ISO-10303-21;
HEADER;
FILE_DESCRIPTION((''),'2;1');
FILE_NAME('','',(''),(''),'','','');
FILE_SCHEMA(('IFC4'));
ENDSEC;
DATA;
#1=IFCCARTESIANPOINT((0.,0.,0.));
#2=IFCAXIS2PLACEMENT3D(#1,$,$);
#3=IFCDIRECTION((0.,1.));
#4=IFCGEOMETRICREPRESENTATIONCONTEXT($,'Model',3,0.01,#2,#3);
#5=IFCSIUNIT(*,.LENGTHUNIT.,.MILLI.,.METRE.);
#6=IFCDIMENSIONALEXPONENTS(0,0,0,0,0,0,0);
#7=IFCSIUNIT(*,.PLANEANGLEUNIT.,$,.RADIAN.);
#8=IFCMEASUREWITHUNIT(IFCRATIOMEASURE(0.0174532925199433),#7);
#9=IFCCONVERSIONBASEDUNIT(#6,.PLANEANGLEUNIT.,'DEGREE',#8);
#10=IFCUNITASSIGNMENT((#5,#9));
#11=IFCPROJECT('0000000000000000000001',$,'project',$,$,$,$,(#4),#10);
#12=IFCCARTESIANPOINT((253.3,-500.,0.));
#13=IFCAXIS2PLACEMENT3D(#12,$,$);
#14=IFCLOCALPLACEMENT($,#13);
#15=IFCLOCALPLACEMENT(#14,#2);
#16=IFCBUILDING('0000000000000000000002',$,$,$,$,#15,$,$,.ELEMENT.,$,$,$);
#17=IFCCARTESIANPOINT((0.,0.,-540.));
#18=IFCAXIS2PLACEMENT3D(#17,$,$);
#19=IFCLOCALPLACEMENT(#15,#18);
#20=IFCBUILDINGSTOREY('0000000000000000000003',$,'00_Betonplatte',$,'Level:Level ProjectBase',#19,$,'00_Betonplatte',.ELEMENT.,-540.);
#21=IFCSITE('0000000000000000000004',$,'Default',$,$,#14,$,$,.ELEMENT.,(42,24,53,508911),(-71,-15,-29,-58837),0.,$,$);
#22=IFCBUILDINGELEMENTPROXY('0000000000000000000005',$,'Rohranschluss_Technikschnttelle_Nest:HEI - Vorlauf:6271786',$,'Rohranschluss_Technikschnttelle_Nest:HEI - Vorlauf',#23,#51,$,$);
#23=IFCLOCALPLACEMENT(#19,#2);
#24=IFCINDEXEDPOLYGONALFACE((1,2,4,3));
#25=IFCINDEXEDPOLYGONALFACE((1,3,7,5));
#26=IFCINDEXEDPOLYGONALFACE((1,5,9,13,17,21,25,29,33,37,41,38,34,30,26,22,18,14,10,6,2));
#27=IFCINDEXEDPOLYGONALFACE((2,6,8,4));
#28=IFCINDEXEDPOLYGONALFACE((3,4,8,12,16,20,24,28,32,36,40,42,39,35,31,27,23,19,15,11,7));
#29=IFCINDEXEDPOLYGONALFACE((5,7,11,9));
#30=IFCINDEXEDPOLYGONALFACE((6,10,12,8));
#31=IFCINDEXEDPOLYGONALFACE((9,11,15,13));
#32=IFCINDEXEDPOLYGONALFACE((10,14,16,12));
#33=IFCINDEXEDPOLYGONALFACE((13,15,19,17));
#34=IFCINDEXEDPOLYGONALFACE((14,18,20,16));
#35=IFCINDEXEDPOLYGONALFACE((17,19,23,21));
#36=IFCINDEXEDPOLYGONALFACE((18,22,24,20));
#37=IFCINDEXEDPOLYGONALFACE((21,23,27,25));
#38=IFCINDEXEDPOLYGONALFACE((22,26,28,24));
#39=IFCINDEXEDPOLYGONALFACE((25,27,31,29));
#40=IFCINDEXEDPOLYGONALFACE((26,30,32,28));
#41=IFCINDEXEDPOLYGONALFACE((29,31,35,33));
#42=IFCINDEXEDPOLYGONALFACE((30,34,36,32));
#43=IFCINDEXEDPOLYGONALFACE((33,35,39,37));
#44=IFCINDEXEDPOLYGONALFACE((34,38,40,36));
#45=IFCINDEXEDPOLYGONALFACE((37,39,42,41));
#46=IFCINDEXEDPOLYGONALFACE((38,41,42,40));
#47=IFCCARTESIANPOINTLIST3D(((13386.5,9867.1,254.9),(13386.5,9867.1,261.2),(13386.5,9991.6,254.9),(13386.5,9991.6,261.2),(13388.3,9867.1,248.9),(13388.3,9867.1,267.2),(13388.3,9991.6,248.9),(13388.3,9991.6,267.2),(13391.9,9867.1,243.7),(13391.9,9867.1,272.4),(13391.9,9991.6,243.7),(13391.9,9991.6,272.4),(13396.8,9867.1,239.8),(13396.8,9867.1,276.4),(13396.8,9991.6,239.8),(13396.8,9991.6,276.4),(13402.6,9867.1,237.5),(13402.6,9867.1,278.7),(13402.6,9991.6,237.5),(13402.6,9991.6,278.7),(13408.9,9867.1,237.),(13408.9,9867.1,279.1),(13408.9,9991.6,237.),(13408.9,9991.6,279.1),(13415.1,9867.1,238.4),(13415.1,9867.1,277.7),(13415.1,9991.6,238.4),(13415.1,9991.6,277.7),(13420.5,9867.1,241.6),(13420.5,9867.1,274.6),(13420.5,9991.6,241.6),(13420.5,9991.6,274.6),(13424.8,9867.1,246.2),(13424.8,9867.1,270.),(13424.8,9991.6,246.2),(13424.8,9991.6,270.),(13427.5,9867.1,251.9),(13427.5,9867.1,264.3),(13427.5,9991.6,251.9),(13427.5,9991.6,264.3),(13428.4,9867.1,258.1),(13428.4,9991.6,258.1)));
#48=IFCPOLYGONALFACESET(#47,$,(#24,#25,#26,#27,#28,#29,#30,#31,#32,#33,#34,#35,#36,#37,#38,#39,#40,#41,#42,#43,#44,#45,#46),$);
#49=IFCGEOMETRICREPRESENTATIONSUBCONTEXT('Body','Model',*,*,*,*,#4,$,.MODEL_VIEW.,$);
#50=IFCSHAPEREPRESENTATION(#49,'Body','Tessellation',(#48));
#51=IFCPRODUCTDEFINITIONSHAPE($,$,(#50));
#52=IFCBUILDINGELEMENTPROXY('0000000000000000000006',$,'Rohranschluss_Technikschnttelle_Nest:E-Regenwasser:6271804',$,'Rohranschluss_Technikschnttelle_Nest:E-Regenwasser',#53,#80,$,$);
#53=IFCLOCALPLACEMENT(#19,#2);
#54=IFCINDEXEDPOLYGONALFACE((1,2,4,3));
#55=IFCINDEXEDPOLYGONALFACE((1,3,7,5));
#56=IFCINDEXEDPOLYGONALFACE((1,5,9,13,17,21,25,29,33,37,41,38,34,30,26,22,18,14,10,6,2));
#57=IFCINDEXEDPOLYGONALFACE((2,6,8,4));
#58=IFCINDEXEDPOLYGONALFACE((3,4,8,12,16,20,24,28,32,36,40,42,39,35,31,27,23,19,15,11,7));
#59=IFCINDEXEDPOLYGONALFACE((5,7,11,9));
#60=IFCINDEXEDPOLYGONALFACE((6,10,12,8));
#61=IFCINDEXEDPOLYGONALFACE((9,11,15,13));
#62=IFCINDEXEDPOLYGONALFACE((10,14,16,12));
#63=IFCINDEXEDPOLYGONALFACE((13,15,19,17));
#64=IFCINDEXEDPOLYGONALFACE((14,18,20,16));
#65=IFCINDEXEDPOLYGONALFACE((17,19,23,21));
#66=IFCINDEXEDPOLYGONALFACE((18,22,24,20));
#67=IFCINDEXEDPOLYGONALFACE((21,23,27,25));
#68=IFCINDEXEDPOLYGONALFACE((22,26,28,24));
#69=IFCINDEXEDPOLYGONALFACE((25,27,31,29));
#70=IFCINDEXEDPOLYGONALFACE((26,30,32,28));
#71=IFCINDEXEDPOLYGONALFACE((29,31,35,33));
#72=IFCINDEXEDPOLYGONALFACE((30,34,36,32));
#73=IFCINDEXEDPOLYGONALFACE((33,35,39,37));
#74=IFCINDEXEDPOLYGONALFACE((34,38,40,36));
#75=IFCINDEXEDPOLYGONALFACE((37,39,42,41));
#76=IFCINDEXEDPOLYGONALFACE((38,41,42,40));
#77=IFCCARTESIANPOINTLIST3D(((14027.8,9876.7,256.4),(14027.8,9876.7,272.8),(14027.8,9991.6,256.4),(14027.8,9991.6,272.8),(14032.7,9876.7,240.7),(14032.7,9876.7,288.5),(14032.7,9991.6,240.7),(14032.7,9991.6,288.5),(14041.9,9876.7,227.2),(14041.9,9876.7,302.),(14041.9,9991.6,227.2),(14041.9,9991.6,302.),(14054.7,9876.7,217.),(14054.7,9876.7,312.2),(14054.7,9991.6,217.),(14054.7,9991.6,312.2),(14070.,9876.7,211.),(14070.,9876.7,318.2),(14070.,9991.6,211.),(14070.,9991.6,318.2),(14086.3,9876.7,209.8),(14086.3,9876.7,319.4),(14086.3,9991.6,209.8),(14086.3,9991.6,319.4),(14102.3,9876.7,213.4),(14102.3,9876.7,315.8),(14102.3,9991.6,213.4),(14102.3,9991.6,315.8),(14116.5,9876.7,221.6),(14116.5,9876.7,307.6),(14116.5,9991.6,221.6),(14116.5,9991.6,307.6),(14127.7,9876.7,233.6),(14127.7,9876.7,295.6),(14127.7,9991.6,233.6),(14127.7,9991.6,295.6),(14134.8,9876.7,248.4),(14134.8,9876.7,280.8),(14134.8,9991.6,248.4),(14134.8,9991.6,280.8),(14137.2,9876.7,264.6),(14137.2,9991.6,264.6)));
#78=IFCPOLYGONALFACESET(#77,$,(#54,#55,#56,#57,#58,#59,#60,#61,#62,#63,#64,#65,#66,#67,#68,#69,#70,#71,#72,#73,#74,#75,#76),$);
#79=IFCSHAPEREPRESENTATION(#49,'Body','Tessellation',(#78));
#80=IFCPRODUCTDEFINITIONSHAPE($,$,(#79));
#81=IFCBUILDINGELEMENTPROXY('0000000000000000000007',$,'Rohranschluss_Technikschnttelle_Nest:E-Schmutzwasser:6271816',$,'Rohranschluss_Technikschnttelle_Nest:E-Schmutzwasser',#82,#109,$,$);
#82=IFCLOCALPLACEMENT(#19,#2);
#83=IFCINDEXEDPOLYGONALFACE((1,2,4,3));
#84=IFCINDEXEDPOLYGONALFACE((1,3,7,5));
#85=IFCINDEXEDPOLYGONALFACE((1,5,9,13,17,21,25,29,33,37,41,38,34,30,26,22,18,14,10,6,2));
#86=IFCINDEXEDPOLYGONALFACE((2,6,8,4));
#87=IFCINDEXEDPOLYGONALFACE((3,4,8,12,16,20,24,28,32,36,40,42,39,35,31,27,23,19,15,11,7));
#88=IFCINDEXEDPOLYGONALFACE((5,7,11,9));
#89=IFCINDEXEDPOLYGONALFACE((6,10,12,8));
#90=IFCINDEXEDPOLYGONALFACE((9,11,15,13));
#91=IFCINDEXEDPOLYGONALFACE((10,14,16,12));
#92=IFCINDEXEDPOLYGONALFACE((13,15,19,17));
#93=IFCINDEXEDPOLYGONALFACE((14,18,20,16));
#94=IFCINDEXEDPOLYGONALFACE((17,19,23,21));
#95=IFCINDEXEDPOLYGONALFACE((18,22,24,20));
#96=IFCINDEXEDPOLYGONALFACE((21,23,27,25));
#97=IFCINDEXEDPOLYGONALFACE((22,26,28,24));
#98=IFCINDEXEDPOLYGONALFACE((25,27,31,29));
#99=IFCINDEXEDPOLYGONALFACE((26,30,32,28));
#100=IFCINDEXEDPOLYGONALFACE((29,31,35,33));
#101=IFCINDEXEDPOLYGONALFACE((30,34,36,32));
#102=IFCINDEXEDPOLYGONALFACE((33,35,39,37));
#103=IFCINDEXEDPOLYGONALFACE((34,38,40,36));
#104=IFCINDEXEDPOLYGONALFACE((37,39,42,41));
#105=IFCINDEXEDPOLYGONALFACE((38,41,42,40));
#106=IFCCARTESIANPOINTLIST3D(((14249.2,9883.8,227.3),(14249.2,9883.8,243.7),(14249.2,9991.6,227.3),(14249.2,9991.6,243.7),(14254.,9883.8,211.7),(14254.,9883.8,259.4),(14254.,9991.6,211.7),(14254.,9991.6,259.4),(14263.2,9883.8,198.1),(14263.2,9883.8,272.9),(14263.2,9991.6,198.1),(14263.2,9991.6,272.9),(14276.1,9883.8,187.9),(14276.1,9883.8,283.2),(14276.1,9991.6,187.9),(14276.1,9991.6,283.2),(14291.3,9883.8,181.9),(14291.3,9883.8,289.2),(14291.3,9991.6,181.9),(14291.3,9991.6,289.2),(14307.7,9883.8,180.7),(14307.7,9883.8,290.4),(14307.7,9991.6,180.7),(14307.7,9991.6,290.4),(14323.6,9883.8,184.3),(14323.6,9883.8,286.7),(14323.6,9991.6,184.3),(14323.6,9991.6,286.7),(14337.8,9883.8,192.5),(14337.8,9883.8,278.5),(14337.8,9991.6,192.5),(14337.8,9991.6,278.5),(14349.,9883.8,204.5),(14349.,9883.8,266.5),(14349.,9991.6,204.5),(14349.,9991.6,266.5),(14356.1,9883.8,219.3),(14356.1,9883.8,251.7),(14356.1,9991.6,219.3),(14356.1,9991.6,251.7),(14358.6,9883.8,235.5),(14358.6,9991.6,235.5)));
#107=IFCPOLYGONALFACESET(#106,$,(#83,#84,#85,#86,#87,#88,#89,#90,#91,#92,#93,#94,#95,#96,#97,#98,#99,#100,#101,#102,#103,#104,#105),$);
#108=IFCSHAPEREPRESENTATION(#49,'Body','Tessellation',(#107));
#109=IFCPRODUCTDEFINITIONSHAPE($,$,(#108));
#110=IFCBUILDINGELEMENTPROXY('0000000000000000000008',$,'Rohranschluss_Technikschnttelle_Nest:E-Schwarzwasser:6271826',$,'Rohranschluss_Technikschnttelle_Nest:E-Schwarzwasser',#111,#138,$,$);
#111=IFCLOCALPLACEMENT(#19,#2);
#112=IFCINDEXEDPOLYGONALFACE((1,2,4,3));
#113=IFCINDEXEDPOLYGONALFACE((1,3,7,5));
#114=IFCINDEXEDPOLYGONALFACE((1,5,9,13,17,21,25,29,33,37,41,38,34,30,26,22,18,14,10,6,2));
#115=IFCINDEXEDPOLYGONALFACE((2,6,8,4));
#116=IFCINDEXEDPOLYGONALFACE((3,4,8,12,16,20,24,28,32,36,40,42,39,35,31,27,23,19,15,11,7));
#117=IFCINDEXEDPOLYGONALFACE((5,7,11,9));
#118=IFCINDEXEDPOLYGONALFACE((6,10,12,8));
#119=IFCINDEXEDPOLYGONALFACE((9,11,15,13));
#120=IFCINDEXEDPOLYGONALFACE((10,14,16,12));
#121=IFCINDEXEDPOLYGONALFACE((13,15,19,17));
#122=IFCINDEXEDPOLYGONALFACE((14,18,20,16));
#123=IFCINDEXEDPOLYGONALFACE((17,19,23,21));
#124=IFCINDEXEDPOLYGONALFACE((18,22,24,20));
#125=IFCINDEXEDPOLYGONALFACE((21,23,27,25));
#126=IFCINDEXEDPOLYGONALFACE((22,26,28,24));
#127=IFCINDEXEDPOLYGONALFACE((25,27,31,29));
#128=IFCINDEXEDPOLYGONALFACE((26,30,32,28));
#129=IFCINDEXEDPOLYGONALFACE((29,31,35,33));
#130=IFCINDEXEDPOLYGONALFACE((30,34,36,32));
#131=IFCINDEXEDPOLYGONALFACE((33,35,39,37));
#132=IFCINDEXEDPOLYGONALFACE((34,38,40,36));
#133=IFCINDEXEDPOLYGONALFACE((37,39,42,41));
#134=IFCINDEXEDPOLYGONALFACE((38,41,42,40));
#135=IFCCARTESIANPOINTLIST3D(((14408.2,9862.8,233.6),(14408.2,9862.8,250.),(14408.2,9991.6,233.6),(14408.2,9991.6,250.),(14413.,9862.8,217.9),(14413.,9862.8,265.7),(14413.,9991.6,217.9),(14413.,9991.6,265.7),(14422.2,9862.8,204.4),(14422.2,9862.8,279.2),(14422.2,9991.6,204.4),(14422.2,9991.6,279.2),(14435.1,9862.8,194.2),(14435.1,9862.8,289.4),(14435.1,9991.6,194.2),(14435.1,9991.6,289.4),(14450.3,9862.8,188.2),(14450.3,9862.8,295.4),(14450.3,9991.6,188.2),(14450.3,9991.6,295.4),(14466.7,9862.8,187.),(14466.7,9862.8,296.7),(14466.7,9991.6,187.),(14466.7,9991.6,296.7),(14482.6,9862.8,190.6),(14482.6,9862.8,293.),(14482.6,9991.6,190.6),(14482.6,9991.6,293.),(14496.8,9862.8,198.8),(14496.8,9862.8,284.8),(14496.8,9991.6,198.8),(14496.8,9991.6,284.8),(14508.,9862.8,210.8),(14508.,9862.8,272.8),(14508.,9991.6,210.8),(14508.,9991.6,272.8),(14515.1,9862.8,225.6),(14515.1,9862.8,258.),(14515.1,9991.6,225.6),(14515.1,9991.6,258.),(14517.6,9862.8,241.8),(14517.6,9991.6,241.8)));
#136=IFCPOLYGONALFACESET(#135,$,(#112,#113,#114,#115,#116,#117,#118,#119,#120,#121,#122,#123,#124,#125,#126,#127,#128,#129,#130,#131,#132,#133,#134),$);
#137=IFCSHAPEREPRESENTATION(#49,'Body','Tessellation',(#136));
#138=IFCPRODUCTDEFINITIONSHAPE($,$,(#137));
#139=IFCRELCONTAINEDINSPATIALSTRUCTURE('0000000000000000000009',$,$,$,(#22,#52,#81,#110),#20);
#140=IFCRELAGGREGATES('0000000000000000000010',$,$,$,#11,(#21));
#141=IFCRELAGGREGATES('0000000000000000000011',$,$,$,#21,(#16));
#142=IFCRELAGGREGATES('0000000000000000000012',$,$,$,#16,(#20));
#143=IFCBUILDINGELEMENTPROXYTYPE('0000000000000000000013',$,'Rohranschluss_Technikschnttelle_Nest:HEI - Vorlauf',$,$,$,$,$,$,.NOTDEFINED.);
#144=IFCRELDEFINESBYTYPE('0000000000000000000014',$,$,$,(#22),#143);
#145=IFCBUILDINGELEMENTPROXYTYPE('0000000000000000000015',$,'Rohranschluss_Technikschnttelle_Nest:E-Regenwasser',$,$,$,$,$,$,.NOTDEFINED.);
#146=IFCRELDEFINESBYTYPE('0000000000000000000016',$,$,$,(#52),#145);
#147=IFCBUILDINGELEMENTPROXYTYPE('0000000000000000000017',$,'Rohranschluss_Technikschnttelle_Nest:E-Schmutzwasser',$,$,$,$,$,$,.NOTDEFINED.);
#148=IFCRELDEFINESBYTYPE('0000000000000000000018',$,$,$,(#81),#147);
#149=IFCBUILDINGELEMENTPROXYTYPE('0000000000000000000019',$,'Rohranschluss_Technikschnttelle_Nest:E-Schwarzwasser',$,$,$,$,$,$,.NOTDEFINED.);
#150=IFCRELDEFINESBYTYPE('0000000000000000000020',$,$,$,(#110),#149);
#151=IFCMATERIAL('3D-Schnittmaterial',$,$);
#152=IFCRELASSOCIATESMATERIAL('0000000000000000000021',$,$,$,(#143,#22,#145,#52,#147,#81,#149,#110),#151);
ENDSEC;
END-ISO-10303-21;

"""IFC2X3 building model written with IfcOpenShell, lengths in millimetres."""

from ifc_helpers import new_model, entity, si_unit, converted_unit, direction, frame, frame_2d, origin, place, context, subcontext, project, spatial, circle, extrude, source, transform, mapped, material, type_object, type_shapes, element, save


model = new_model("IFC2X3")

# Units and contexts
model_context = context("Model", 3, precision=0.01, world=origin(), true_north=direction((0.0, 1.0)))
body_context = subcontext(model_context, "Body", "Model", "MODEL_VIEW")
ifc_project = project(units=[si_unit("LENGTHUNIT", "METRE", prefix="MILLI"), converted_unit("PLANEANGLEUNIT", "DEGREE", entity("IfcRatioMeasure", 0.0174532925199433), si_unit("PLANEANGLEUNIT", "RADIAN"), dimensions=[0, 0, 0, 0, 0, 0, 0])], contexts=[model_context])

# Site, building, storey
site_placement = place(None, frame((253.3, -500.0, 0.0)))
site = spatial("IfcSite", under=ifc_project, at=site_placement, Name="Default", CompositionType="ELEMENT", RefLatitude=(42, 24, 53, 508911), RefLongitude=(-71, -15, -29, -58837), RefElevation=0.0)
building_placement = place(site_placement, origin())
building = spatial("IfcBuilding", under=site, at=building_placement, CompositionType="ELEMENT")
storey_placement = place(building_placement, frame((0.0, 0.0, -540.0)))
storey = spatial("IfcBuildingStorey", under=building, at=storey_placement, Name="00_Betonplatte", ObjectType="Level:Level ProjectBase", LongName="00_Betonplatte", CompositionType="ELEMENT", Elevation=-540.0)

# Building element proxies
ifc_material_1 = material(Name="3D-Schnittmaterial")
building_element_proxy_type_1 = type_object("IfcBuildingElementProxyType", Name="Rohranschluss_Technikschnttelle_Nest:HEI - Vorlauf", PredefinedType="NOTDEFINED", material=ifc_material_1)
shared_shape_1 = source(origin(), body_context, "Body", "SweptSolid", [
    extrude(circle(Radius=21.1, at=frame_2d((0.0, 0.0), x_axis=(1.0, 0.0))), frame((0.0, -124.5, 0.0), z_axis=(0.0, 1.0, 0.0), x_axis=(1.0, 0.0, 0.0)), (0.0, 0.0, 1.0), 124.5),
])
type_shapes(building_element_proxy_type_1, [shared_shape_1])
proxy_1_placement = place(storey_placement, frame((13407.3, 9991.6, 258.1)))
element("IfcBuildingElementProxy", 1, at=proxy_1_placement, inside=storey, type_object=building_element_proxy_type_1, material=ifc_material_1, Name="Rohranschluss_Technikschnttelle_Nest:HEI - Vorlauf:6271786", ObjectType="Rohranschluss_Technikschnttelle_Nest:HEI - Vorlauf", context=body_context, shape_type="MappedRepresentation", body=[
    mapped(shared_shape_1, transform((0.0, 0.0, 0.0), scale=1.0)),
])
building_element_proxy_type_2 = type_object("IfcBuildingElementProxyType", Name="Rohranschluss_Technikschnttelle_Nest:E-Regenwasser", PredefinedType="NOTDEFINED", material=ifc_material_1)
shared_shape_2 = source(origin(), body_context, "Body", "SweptSolid", [
    extrude(circle(Radius=55.0, at=frame_2d((0.0, 0.0), x_axis=(1.0, 0.0))), frame((0.0, -115.0, 0.0), z_axis=(0.0, 1.0, 0.0), x_axis=(1.0, 0.0, 0.0)), (0.0, 0.0, 1.0), 115.0),
])
type_shapes(building_element_proxy_type_2, [shared_shape_2])
proxy_2_placement = place(storey_placement, frame((14082.2, 9991.6, 264.6)))
element("IfcBuildingElementProxy", 2, at=proxy_2_placement, inside=storey, type_object=building_element_proxy_type_2, material=ifc_material_1, Name="Rohranschluss_Technikschnttelle_Nest:E-Regenwasser:6271804", ObjectType="Rohranschluss_Technikschnttelle_Nest:E-Regenwasser", context=body_context, shape_type="MappedRepresentation", body=[
    mapped(shared_shape_2, transform((0.0, 0.0, 0.0), scale=1.0)),
])
building_element_proxy_type_3 = type_object("IfcBuildingElementProxyType", Name="Rohranschluss_Technikschnttelle_Nest:E-Schmutzwasser", PredefinedType="NOTDEFINED", material=ifc_material_1)
shared_shape_3 = source(origin(), body_context, "Body", "SweptSolid", [
    extrude(circle(Radius=55.0, at=frame_2d((0.0, 0.0), x_axis=(1.0, 0.0))), frame((0.0, -107.9, 0.0), z_axis=(0.0, 1.0, 0.0), x_axis=(1.0, 0.0, 0.0)), (0.0, 0.0, 1.0), 107.9),
])
type_shapes(building_element_proxy_type_3, [shared_shape_3])
proxy_3_placement = place(storey_placement, frame((14303.6, 9991.6, 235.5)))
element("IfcBuildingElementProxy", 3, at=proxy_3_placement, inside=storey, type_object=building_element_proxy_type_3, material=ifc_material_1, Name="Rohranschluss_Technikschnttelle_Nest:E-Schmutzwasser:6271816", ObjectType="Rohranschluss_Technikschnttelle_Nest:E-Schmutzwasser", context=body_context, shape_type="MappedRepresentation", body=[
    mapped(shared_shape_3, transform((0.0, 0.0, 0.0), scale=1.0)),
])
building_element_proxy_type_4 = type_object("IfcBuildingElementProxyType", Name="Rohranschluss_Technikschnttelle_Nest:E-Schwarzwasser", PredefinedType="NOTDEFINED", material=ifc_material_1)
shared_shape_4 = source(origin(), body_context, "Body", "SweptSolid", [
    extrude(circle(Radius=55.0, at=frame_2d((0.0, 0.0), x_axis=(1.0, 0.0))), frame((0.0, -128.8, 0.0), z_axis=(0.0, 1.0, 0.0), x_axis=(1.0, 0.0, 0.0)), (0.0, 0.0, 1.0), 128.8),
])
type_shapes(building_element_proxy_type_4, [shared_shape_4])
proxy_4_placement = place(storey_placement, frame((14462.6, 9991.6, 241.8)))
element("IfcBuildingElementProxy", 4, at=proxy_4_placement, inside=storey, type_object=building_element_proxy_type_4, material=ifc_material_1, Name="Rohranschluss_Technikschnttelle_Nest:E-Schwarzwasser:6271826", ObjectType="Rohranschluss_Technikschnttelle_Nest:E-Schwarzwasser", context=body_context, shape_type="MappedRepresentation", body=[
    mapped(shared_shape_4, transform((0.0, 0.0, 0.0), scale=1.0)),
])

save(model, "model.ifc")
